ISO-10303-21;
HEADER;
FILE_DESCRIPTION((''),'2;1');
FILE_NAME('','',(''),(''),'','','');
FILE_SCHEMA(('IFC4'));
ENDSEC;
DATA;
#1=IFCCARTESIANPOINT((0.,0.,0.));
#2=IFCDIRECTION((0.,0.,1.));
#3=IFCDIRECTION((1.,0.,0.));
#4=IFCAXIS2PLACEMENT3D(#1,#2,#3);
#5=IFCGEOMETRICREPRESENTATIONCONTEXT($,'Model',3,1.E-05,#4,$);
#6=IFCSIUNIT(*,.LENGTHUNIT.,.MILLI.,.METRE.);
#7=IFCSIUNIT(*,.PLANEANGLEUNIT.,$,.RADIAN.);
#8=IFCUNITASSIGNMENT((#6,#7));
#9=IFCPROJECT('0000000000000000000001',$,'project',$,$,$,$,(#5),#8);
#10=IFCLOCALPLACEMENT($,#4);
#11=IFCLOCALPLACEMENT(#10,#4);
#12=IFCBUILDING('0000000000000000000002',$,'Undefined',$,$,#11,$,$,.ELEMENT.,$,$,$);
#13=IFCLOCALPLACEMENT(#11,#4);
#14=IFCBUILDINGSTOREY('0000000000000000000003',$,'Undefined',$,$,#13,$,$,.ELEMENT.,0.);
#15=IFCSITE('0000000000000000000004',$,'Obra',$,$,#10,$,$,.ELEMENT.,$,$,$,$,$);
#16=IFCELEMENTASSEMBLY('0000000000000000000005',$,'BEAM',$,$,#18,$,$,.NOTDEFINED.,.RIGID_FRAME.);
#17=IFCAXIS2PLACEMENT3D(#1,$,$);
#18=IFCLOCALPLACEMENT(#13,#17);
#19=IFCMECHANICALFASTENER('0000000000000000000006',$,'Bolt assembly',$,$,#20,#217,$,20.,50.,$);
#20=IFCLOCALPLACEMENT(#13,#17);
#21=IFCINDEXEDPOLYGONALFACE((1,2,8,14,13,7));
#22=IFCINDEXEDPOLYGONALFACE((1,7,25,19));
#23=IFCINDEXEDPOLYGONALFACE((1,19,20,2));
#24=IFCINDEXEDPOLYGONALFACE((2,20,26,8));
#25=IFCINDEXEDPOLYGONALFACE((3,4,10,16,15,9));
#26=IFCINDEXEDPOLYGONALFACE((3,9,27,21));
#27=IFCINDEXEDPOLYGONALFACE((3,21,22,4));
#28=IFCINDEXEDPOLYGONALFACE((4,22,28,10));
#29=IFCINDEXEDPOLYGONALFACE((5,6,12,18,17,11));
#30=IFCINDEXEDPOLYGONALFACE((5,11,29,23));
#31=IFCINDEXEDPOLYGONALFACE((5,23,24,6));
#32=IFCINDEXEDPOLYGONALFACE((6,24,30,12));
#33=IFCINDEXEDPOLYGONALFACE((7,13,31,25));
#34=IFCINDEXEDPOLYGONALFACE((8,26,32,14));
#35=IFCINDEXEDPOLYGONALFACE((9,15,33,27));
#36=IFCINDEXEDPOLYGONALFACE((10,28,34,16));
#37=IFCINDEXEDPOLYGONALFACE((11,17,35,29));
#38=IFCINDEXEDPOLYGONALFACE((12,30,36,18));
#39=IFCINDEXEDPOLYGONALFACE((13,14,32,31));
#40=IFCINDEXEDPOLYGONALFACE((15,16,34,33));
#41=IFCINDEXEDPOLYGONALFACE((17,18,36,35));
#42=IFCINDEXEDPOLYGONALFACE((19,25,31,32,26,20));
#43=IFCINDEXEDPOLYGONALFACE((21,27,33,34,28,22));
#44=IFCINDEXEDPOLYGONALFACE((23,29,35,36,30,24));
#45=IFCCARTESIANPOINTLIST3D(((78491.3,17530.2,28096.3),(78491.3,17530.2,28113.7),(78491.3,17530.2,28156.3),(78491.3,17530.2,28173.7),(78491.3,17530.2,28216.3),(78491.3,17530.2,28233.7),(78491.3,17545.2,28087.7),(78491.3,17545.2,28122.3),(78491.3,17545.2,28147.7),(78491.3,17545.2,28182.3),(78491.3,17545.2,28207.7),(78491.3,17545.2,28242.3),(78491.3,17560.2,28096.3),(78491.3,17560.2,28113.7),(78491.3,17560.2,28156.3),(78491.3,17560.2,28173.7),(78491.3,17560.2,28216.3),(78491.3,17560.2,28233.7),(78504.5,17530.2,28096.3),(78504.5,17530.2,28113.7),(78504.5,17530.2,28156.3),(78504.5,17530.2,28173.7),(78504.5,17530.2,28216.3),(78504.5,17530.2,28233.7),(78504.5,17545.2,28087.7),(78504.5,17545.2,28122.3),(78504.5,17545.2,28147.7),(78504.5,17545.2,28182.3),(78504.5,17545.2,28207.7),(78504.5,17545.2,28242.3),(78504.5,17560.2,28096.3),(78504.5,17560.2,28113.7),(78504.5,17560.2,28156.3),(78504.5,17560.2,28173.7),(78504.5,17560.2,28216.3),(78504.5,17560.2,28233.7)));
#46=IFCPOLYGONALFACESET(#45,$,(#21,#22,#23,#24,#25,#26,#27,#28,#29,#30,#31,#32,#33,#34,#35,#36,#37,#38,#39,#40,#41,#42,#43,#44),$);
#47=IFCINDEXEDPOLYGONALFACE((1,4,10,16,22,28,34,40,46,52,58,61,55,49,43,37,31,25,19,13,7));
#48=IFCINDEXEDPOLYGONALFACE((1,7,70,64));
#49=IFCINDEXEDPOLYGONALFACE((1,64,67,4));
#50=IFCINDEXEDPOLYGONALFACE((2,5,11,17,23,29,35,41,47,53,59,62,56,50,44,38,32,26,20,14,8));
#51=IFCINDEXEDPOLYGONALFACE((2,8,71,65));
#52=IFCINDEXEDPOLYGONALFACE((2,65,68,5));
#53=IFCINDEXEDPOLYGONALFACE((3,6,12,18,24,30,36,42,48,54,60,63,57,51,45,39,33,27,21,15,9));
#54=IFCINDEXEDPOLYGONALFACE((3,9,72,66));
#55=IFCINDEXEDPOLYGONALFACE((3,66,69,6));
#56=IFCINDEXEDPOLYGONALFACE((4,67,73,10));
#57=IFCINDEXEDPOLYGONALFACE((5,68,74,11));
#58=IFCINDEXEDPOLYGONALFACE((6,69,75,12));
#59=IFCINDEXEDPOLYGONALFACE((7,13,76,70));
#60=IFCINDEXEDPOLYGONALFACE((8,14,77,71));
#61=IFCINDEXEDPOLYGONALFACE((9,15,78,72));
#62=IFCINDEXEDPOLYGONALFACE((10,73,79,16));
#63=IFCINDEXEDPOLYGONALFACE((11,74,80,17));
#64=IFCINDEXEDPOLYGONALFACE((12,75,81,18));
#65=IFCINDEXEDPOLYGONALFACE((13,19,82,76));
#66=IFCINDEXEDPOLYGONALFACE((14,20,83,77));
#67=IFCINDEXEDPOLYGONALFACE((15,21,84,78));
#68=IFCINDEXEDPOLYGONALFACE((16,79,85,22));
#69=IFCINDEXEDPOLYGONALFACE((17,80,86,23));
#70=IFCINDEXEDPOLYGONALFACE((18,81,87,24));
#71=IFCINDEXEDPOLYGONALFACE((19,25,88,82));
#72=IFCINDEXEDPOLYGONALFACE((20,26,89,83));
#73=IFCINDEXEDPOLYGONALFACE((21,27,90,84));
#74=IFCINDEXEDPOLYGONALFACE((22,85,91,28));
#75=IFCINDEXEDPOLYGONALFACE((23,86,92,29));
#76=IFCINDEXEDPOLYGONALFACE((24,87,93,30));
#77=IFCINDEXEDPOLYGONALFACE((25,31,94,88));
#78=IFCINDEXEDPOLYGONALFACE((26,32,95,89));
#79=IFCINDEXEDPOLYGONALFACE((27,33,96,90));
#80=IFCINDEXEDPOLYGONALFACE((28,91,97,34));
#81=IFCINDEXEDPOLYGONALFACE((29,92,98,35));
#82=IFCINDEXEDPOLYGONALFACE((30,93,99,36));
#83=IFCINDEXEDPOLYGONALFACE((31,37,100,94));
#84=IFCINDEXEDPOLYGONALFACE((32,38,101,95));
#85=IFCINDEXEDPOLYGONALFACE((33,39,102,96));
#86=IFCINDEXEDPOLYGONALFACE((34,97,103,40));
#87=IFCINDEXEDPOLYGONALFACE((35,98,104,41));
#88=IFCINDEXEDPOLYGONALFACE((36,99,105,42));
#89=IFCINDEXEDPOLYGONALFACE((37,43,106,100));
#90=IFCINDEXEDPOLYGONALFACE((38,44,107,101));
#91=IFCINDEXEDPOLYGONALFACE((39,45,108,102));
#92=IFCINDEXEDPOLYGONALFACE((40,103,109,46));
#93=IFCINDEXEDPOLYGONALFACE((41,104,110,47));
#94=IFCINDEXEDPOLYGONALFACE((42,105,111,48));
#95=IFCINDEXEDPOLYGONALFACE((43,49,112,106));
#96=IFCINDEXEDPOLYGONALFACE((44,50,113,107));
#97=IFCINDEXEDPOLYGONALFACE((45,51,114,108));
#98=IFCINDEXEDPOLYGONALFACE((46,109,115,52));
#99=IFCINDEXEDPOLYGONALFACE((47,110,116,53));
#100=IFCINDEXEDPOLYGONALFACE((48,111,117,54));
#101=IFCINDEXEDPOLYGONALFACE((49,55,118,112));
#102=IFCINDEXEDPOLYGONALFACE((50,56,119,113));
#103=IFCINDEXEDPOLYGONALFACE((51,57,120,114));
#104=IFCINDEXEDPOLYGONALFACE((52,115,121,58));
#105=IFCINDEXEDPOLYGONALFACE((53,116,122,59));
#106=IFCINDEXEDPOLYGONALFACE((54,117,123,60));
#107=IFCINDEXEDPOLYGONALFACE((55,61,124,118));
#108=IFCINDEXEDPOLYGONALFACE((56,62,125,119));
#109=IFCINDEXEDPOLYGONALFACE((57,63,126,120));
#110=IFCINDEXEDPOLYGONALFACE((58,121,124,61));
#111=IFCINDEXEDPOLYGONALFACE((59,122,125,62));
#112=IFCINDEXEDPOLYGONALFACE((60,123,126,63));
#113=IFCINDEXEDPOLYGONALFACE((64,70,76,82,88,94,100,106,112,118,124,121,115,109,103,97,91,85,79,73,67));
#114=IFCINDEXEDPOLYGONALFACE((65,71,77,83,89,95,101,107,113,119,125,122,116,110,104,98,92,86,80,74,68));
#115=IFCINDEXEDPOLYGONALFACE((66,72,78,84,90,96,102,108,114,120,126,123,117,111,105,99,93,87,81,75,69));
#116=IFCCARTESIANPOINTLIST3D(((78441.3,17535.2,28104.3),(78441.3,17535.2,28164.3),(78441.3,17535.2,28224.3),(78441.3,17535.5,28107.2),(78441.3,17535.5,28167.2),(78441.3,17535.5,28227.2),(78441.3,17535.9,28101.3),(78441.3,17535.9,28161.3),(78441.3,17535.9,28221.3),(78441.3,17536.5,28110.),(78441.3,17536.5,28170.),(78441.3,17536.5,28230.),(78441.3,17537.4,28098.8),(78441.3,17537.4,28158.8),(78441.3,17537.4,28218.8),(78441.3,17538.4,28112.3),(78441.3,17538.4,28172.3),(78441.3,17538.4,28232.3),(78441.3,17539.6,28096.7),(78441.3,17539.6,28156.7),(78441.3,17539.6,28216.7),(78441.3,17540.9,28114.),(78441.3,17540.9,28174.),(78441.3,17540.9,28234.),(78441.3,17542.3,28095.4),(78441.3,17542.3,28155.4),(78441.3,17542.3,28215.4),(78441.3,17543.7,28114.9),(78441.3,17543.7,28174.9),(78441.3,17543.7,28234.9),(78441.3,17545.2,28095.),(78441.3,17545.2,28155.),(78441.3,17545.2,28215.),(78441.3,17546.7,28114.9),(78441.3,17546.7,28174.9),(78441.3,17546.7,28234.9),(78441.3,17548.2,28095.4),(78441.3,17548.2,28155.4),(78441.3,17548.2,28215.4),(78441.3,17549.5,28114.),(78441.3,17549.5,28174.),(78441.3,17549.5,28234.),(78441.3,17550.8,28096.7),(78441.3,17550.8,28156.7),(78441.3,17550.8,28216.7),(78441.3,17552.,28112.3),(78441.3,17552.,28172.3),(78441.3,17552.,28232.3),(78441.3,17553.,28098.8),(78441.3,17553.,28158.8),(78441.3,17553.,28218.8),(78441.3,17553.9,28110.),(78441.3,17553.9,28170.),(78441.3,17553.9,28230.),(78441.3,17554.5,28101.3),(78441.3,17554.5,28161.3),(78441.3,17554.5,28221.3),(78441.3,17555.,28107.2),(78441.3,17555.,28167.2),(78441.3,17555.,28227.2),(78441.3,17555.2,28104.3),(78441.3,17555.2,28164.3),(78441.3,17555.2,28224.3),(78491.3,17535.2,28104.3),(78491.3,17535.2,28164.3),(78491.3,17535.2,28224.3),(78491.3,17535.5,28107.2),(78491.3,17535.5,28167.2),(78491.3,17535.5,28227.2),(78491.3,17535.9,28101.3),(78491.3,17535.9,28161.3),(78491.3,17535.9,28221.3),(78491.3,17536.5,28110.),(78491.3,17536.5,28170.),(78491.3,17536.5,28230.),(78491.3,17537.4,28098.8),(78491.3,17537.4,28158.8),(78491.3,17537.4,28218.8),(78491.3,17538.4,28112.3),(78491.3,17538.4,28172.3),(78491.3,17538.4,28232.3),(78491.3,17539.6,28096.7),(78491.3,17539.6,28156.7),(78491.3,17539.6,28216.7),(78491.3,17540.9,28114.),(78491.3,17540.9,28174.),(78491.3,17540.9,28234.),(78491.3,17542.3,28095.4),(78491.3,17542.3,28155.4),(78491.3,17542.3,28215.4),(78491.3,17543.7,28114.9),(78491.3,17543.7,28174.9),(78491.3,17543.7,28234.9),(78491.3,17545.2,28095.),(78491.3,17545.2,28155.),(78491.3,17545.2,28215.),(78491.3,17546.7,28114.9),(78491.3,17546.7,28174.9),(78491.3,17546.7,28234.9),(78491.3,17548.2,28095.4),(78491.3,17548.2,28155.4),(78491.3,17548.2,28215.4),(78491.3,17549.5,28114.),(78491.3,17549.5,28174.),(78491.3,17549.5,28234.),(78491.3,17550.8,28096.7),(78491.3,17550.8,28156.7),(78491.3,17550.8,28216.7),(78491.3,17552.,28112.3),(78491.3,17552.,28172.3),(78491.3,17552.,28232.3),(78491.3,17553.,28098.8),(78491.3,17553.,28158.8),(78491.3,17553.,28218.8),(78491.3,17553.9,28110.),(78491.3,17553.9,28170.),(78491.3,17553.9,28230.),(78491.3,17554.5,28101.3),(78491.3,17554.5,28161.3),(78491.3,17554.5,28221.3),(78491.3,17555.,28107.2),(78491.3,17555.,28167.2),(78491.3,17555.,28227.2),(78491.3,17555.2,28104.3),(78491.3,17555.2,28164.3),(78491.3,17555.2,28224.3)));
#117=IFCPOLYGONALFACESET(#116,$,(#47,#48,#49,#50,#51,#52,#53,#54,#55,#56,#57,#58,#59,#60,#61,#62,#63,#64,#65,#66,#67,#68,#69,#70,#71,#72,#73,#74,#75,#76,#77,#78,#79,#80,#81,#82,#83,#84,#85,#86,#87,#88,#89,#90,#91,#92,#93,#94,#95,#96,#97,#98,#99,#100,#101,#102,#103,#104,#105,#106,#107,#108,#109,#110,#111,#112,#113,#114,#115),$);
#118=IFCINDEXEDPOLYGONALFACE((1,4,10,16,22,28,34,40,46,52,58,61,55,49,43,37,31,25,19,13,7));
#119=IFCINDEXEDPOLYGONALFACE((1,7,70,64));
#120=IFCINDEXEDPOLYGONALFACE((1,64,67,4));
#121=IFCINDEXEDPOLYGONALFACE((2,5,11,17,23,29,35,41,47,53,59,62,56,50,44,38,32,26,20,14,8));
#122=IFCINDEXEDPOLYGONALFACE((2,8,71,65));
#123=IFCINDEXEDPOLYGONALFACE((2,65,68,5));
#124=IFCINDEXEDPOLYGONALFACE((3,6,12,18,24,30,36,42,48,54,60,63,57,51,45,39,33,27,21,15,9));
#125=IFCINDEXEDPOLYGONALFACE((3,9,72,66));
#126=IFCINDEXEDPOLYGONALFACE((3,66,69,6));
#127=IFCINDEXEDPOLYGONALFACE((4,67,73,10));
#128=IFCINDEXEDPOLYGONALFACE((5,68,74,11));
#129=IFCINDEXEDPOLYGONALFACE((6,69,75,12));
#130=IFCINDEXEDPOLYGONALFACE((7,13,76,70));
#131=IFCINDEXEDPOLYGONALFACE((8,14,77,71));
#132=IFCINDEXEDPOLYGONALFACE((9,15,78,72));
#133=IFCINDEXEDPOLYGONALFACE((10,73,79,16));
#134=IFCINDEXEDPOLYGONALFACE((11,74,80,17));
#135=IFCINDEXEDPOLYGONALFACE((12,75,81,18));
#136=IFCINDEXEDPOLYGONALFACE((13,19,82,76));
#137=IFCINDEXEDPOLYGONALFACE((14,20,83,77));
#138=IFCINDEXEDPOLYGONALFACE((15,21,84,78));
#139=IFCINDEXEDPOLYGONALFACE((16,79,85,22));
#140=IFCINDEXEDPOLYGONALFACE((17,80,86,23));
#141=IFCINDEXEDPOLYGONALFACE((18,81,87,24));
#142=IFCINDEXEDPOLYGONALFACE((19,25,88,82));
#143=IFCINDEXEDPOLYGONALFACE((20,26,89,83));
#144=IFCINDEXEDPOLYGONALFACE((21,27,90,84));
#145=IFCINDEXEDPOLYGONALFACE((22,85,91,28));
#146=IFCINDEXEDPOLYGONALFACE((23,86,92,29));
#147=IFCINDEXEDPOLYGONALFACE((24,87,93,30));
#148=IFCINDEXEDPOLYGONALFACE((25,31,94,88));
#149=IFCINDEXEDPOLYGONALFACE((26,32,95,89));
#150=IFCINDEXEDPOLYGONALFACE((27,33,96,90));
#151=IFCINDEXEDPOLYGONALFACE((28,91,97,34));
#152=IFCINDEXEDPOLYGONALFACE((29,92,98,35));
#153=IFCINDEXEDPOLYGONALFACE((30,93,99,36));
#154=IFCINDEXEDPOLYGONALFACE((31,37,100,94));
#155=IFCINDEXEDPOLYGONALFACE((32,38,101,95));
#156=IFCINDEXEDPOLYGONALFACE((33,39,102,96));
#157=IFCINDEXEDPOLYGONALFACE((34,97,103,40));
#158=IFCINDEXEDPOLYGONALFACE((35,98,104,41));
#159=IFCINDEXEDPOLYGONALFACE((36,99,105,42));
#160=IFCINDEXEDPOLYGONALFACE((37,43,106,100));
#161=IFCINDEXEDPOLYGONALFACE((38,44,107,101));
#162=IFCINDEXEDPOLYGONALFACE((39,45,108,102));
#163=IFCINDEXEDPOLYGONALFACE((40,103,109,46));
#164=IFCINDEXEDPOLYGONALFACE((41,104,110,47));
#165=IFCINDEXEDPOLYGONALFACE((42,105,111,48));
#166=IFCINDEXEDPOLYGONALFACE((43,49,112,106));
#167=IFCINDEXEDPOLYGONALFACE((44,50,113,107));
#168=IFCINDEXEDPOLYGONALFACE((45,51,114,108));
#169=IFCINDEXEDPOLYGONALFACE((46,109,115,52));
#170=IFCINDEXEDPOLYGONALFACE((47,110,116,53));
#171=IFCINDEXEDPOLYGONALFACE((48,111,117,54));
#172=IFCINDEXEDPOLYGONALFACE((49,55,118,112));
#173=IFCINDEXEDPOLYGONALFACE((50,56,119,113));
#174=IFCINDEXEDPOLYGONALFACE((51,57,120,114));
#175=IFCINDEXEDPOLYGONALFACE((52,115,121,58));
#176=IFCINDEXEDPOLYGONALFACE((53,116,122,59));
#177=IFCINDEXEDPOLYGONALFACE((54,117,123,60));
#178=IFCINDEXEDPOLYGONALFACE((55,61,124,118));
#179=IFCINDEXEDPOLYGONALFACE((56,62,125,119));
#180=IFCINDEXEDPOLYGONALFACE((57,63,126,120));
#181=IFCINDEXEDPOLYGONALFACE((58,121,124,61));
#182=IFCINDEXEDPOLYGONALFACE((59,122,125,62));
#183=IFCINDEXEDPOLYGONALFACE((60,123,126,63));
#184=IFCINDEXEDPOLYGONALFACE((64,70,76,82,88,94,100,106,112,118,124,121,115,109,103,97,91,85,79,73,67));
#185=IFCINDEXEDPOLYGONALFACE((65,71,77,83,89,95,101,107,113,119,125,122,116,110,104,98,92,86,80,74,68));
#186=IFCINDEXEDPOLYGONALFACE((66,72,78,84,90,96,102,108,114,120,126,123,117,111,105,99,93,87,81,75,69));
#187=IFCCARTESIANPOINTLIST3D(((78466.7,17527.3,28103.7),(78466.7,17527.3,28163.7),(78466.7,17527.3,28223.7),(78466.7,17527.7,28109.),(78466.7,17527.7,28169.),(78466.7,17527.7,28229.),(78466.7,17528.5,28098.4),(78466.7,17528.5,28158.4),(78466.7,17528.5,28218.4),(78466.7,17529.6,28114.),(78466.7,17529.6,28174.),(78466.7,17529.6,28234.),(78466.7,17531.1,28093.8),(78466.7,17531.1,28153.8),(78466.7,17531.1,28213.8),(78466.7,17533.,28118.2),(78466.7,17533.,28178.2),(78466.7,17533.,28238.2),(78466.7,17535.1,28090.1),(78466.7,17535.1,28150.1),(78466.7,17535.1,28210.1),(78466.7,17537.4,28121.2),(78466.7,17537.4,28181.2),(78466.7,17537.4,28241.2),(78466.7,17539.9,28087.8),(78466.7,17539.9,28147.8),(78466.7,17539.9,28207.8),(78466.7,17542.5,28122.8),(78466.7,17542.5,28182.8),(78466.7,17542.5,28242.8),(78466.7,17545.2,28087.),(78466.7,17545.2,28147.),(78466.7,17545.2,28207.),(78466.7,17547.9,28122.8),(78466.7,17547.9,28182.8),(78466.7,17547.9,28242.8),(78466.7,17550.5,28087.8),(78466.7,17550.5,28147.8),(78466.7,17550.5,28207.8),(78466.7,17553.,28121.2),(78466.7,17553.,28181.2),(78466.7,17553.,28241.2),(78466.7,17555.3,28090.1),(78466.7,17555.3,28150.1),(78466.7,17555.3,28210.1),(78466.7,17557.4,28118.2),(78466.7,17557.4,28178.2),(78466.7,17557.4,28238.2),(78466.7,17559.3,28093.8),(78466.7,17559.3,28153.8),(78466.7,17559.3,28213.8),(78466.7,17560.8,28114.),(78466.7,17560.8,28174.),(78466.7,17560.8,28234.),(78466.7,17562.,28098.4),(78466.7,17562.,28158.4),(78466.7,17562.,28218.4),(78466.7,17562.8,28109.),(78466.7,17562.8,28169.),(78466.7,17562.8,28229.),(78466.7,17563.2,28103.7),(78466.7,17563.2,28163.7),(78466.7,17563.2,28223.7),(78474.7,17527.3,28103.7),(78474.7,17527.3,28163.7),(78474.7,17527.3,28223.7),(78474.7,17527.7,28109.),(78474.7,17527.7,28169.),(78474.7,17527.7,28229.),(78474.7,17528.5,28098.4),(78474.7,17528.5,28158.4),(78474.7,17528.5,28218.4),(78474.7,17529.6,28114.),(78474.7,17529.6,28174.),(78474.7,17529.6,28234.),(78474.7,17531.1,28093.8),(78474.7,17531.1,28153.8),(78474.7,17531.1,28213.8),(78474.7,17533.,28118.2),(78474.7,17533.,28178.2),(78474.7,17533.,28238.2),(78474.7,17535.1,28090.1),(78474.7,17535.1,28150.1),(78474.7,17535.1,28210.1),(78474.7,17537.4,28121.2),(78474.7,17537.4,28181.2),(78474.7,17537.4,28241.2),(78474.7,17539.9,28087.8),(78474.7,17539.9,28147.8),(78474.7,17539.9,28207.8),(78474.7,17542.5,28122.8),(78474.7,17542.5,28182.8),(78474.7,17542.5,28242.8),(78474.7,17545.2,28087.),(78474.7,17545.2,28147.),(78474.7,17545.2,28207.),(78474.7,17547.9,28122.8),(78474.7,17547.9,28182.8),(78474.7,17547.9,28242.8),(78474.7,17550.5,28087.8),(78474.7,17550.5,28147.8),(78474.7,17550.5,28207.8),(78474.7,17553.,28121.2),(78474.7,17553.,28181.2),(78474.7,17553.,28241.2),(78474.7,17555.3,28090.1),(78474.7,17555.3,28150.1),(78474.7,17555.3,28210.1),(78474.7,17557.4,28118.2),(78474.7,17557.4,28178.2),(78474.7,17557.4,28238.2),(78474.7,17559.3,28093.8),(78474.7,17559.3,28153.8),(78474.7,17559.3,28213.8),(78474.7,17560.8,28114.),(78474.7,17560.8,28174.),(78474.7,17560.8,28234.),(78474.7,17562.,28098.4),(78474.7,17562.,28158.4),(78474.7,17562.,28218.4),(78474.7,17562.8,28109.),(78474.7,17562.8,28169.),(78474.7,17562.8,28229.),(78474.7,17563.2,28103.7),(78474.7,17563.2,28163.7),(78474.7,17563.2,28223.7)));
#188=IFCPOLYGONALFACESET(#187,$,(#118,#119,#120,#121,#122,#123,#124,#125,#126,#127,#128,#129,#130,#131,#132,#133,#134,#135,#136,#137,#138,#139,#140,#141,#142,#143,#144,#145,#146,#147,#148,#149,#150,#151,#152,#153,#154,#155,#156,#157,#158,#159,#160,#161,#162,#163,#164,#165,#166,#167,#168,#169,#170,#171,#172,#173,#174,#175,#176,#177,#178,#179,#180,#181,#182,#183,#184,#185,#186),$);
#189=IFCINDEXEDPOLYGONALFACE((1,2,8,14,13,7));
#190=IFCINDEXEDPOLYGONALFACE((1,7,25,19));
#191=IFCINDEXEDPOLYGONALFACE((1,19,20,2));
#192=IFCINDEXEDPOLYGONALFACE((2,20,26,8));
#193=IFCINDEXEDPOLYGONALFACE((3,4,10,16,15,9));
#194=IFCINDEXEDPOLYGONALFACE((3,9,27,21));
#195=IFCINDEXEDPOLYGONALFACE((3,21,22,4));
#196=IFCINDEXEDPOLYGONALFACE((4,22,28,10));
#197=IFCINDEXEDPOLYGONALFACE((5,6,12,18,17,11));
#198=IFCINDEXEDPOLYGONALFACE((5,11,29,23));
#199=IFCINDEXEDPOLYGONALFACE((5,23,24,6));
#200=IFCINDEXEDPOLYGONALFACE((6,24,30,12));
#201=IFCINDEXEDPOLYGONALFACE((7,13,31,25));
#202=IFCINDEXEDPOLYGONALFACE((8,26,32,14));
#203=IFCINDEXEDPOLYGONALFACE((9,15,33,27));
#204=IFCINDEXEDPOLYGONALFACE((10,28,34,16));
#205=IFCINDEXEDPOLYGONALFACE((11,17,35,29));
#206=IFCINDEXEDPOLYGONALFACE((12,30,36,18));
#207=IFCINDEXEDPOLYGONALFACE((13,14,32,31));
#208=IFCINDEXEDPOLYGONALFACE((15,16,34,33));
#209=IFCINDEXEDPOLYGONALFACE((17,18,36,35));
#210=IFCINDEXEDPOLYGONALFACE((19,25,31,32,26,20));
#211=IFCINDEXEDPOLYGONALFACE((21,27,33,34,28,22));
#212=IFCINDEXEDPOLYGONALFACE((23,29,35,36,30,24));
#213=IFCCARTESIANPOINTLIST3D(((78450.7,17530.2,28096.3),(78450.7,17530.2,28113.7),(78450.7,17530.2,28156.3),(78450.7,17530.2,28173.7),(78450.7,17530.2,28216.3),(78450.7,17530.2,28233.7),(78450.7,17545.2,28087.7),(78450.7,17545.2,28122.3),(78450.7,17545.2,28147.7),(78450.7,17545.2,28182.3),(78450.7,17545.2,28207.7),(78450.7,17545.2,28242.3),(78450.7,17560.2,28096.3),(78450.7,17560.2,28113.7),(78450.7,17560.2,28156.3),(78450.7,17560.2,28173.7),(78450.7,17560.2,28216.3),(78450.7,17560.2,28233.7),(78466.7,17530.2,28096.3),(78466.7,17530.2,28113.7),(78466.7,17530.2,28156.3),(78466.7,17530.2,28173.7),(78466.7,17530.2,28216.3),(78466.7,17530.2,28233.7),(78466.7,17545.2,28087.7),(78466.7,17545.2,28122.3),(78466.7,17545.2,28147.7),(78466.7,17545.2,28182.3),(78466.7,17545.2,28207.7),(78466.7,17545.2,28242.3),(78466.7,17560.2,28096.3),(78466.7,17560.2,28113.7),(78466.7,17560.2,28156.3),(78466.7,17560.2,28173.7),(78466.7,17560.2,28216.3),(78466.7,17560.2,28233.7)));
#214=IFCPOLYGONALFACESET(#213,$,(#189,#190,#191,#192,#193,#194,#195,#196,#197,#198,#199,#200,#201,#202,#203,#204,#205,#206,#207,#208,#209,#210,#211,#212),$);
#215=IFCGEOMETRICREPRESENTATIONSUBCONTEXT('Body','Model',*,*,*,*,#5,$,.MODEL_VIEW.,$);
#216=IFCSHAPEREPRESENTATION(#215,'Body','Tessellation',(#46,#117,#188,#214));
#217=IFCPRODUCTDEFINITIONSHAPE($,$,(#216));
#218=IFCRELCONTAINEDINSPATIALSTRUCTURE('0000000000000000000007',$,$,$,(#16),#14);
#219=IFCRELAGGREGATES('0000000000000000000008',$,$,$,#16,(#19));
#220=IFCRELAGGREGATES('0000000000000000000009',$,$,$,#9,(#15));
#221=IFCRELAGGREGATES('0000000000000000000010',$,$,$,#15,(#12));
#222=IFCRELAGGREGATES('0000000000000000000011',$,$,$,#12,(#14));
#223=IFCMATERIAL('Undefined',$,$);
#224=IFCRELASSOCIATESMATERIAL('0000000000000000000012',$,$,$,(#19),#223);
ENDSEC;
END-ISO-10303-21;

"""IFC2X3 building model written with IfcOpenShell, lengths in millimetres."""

from ifc_helpers import new_model, si_unit, frame, origin_with_axes, origin_2d_with_axis, place, context, subcontext, project, spatial, polyline, circle, outline, extrude, source, transform, mapped, material, element, aggregate, save


model = new_model("IFC2X3")

# Units and contexts
model_context = context("Model", 3, precision=1e-05, world=origin_with_axes())
body_context = subcontext(model_context, "Body", "Model", "MODEL_VIEW")
ifc_project = project(units=[si_unit("LENGTHUNIT", "METRE", prefix="MILLI"), si_unit("PLANEANGLEUNIT", "RADIAN")], contexts=[model_context])

# Site, building, storey
site_placement = place(None, origin_with_axes())
site = spatial("IfcSite", under=ifc_project, at=site_placement, Name="Obra", CompositionType="ELEMENT")
building_placement = place(site_placement, origin_with_axes())
building = spatial("IfcBuilding", under=site, at=building_placement, Name="Undefined", CompositionType="ELEMENT")
storey_placement = place(building_placement, origin_with_axes())
storey = spatial("IfcBuildingStorey", under=building, at=storey_placement, Name="Undefined", CompositionType="ELEMENT", Elevation=0.0)

# Element assembly
assembly_1_placement = place(storey_placement, origin_with_axes())
assembly_1 = element("IfcElementAssembly", 1, at=assembly_1_placement, inside=storey, Name="BEAM", AssemblyPlace="NOTDEFINED", PredefinedType="RIGID_FRAME")

# Shared definitions
ifc_material_1 = material(Name="Undefined")
shared_shape_1 = source(origin_with_axes(), body_context, "Body", "SweptSolid", [
    extrude(outline(polyline([(17.3, 0.0), (8.7, 15.0), (-8.7, 15.0), (-17.3, 0.0), (-8.7, -15.0), (8.7, -15.0), (17.3, 0.0)])), frame((0.0, -26.5, 0.0), z_axis=(0.0, 1.0, 0.0), x_axis=(1.0, 0.0, 0.0)), (0.0, 0.0, 1.0), 13.2),
    extrude(circle(Radius=10.0, at=origin_2d_with_axis()), frame((0.0, -13.3, 0.0), z_axis=(0.0, 1.0, 0.0), x_axis=(1.0, 0.0, 0.0)), (0.0, 0.0, 1.0), 50.0),
    extrude(circle(Radius=18.0, at=origin_2d_with_axis()), frame((0.0, 3.3, 0.0), z_axis=(0.0, 1.0, 0.0), x_axis=(1.0, 0.0, 0.0)), (0.0, 0.0, 1.0), 8.0),
    extrude(outline(polyline([(17.3, 0.0), (8.7, 15.0), (-8.7, 15.0), (-17.3, 0.0), (-8.7, -15.0), (8.7, -15.0), (17.3, 0.0)])), frame((0.0, 11.3, 0.0), z_axis=(0.0, 1.0, 0.0), x_axis=(1.0, 0.0, 0.0)), (0.0, 0.0, 1.0), 16.0),
])

# Mechanical fastener
mechanical_fastener_1_placement = place(assembly_1_placement, frame((78478.0, 17495.2, 28265.0), z_axis=(0.0, 1.0, 0.0), x_axis=(0.0, 0.0, -1.0)))
mechanical_fastener_1 = element("IfcMechanicalFastener", 2, at=mechanical_fastener_1_placement, material=ifc_material_1, Name="Bolt assembly", NominalDiameter=20.0, NominalLength=50.0, context=body_context, shape_type="MappedRepresentation", body=[
    mapped(shared_shape_1, transform((40.0, 0.0, 50.0))),
    mapped(shared_shape_1, transform((100.0, 0.0, 50.0))),
    mapped(shared_shape_1, transform((160.0, 0.0, 50.0))),
])
aggregate(assembly_1, [mechanical_fastener_1])

save(model, "model.ifc")
